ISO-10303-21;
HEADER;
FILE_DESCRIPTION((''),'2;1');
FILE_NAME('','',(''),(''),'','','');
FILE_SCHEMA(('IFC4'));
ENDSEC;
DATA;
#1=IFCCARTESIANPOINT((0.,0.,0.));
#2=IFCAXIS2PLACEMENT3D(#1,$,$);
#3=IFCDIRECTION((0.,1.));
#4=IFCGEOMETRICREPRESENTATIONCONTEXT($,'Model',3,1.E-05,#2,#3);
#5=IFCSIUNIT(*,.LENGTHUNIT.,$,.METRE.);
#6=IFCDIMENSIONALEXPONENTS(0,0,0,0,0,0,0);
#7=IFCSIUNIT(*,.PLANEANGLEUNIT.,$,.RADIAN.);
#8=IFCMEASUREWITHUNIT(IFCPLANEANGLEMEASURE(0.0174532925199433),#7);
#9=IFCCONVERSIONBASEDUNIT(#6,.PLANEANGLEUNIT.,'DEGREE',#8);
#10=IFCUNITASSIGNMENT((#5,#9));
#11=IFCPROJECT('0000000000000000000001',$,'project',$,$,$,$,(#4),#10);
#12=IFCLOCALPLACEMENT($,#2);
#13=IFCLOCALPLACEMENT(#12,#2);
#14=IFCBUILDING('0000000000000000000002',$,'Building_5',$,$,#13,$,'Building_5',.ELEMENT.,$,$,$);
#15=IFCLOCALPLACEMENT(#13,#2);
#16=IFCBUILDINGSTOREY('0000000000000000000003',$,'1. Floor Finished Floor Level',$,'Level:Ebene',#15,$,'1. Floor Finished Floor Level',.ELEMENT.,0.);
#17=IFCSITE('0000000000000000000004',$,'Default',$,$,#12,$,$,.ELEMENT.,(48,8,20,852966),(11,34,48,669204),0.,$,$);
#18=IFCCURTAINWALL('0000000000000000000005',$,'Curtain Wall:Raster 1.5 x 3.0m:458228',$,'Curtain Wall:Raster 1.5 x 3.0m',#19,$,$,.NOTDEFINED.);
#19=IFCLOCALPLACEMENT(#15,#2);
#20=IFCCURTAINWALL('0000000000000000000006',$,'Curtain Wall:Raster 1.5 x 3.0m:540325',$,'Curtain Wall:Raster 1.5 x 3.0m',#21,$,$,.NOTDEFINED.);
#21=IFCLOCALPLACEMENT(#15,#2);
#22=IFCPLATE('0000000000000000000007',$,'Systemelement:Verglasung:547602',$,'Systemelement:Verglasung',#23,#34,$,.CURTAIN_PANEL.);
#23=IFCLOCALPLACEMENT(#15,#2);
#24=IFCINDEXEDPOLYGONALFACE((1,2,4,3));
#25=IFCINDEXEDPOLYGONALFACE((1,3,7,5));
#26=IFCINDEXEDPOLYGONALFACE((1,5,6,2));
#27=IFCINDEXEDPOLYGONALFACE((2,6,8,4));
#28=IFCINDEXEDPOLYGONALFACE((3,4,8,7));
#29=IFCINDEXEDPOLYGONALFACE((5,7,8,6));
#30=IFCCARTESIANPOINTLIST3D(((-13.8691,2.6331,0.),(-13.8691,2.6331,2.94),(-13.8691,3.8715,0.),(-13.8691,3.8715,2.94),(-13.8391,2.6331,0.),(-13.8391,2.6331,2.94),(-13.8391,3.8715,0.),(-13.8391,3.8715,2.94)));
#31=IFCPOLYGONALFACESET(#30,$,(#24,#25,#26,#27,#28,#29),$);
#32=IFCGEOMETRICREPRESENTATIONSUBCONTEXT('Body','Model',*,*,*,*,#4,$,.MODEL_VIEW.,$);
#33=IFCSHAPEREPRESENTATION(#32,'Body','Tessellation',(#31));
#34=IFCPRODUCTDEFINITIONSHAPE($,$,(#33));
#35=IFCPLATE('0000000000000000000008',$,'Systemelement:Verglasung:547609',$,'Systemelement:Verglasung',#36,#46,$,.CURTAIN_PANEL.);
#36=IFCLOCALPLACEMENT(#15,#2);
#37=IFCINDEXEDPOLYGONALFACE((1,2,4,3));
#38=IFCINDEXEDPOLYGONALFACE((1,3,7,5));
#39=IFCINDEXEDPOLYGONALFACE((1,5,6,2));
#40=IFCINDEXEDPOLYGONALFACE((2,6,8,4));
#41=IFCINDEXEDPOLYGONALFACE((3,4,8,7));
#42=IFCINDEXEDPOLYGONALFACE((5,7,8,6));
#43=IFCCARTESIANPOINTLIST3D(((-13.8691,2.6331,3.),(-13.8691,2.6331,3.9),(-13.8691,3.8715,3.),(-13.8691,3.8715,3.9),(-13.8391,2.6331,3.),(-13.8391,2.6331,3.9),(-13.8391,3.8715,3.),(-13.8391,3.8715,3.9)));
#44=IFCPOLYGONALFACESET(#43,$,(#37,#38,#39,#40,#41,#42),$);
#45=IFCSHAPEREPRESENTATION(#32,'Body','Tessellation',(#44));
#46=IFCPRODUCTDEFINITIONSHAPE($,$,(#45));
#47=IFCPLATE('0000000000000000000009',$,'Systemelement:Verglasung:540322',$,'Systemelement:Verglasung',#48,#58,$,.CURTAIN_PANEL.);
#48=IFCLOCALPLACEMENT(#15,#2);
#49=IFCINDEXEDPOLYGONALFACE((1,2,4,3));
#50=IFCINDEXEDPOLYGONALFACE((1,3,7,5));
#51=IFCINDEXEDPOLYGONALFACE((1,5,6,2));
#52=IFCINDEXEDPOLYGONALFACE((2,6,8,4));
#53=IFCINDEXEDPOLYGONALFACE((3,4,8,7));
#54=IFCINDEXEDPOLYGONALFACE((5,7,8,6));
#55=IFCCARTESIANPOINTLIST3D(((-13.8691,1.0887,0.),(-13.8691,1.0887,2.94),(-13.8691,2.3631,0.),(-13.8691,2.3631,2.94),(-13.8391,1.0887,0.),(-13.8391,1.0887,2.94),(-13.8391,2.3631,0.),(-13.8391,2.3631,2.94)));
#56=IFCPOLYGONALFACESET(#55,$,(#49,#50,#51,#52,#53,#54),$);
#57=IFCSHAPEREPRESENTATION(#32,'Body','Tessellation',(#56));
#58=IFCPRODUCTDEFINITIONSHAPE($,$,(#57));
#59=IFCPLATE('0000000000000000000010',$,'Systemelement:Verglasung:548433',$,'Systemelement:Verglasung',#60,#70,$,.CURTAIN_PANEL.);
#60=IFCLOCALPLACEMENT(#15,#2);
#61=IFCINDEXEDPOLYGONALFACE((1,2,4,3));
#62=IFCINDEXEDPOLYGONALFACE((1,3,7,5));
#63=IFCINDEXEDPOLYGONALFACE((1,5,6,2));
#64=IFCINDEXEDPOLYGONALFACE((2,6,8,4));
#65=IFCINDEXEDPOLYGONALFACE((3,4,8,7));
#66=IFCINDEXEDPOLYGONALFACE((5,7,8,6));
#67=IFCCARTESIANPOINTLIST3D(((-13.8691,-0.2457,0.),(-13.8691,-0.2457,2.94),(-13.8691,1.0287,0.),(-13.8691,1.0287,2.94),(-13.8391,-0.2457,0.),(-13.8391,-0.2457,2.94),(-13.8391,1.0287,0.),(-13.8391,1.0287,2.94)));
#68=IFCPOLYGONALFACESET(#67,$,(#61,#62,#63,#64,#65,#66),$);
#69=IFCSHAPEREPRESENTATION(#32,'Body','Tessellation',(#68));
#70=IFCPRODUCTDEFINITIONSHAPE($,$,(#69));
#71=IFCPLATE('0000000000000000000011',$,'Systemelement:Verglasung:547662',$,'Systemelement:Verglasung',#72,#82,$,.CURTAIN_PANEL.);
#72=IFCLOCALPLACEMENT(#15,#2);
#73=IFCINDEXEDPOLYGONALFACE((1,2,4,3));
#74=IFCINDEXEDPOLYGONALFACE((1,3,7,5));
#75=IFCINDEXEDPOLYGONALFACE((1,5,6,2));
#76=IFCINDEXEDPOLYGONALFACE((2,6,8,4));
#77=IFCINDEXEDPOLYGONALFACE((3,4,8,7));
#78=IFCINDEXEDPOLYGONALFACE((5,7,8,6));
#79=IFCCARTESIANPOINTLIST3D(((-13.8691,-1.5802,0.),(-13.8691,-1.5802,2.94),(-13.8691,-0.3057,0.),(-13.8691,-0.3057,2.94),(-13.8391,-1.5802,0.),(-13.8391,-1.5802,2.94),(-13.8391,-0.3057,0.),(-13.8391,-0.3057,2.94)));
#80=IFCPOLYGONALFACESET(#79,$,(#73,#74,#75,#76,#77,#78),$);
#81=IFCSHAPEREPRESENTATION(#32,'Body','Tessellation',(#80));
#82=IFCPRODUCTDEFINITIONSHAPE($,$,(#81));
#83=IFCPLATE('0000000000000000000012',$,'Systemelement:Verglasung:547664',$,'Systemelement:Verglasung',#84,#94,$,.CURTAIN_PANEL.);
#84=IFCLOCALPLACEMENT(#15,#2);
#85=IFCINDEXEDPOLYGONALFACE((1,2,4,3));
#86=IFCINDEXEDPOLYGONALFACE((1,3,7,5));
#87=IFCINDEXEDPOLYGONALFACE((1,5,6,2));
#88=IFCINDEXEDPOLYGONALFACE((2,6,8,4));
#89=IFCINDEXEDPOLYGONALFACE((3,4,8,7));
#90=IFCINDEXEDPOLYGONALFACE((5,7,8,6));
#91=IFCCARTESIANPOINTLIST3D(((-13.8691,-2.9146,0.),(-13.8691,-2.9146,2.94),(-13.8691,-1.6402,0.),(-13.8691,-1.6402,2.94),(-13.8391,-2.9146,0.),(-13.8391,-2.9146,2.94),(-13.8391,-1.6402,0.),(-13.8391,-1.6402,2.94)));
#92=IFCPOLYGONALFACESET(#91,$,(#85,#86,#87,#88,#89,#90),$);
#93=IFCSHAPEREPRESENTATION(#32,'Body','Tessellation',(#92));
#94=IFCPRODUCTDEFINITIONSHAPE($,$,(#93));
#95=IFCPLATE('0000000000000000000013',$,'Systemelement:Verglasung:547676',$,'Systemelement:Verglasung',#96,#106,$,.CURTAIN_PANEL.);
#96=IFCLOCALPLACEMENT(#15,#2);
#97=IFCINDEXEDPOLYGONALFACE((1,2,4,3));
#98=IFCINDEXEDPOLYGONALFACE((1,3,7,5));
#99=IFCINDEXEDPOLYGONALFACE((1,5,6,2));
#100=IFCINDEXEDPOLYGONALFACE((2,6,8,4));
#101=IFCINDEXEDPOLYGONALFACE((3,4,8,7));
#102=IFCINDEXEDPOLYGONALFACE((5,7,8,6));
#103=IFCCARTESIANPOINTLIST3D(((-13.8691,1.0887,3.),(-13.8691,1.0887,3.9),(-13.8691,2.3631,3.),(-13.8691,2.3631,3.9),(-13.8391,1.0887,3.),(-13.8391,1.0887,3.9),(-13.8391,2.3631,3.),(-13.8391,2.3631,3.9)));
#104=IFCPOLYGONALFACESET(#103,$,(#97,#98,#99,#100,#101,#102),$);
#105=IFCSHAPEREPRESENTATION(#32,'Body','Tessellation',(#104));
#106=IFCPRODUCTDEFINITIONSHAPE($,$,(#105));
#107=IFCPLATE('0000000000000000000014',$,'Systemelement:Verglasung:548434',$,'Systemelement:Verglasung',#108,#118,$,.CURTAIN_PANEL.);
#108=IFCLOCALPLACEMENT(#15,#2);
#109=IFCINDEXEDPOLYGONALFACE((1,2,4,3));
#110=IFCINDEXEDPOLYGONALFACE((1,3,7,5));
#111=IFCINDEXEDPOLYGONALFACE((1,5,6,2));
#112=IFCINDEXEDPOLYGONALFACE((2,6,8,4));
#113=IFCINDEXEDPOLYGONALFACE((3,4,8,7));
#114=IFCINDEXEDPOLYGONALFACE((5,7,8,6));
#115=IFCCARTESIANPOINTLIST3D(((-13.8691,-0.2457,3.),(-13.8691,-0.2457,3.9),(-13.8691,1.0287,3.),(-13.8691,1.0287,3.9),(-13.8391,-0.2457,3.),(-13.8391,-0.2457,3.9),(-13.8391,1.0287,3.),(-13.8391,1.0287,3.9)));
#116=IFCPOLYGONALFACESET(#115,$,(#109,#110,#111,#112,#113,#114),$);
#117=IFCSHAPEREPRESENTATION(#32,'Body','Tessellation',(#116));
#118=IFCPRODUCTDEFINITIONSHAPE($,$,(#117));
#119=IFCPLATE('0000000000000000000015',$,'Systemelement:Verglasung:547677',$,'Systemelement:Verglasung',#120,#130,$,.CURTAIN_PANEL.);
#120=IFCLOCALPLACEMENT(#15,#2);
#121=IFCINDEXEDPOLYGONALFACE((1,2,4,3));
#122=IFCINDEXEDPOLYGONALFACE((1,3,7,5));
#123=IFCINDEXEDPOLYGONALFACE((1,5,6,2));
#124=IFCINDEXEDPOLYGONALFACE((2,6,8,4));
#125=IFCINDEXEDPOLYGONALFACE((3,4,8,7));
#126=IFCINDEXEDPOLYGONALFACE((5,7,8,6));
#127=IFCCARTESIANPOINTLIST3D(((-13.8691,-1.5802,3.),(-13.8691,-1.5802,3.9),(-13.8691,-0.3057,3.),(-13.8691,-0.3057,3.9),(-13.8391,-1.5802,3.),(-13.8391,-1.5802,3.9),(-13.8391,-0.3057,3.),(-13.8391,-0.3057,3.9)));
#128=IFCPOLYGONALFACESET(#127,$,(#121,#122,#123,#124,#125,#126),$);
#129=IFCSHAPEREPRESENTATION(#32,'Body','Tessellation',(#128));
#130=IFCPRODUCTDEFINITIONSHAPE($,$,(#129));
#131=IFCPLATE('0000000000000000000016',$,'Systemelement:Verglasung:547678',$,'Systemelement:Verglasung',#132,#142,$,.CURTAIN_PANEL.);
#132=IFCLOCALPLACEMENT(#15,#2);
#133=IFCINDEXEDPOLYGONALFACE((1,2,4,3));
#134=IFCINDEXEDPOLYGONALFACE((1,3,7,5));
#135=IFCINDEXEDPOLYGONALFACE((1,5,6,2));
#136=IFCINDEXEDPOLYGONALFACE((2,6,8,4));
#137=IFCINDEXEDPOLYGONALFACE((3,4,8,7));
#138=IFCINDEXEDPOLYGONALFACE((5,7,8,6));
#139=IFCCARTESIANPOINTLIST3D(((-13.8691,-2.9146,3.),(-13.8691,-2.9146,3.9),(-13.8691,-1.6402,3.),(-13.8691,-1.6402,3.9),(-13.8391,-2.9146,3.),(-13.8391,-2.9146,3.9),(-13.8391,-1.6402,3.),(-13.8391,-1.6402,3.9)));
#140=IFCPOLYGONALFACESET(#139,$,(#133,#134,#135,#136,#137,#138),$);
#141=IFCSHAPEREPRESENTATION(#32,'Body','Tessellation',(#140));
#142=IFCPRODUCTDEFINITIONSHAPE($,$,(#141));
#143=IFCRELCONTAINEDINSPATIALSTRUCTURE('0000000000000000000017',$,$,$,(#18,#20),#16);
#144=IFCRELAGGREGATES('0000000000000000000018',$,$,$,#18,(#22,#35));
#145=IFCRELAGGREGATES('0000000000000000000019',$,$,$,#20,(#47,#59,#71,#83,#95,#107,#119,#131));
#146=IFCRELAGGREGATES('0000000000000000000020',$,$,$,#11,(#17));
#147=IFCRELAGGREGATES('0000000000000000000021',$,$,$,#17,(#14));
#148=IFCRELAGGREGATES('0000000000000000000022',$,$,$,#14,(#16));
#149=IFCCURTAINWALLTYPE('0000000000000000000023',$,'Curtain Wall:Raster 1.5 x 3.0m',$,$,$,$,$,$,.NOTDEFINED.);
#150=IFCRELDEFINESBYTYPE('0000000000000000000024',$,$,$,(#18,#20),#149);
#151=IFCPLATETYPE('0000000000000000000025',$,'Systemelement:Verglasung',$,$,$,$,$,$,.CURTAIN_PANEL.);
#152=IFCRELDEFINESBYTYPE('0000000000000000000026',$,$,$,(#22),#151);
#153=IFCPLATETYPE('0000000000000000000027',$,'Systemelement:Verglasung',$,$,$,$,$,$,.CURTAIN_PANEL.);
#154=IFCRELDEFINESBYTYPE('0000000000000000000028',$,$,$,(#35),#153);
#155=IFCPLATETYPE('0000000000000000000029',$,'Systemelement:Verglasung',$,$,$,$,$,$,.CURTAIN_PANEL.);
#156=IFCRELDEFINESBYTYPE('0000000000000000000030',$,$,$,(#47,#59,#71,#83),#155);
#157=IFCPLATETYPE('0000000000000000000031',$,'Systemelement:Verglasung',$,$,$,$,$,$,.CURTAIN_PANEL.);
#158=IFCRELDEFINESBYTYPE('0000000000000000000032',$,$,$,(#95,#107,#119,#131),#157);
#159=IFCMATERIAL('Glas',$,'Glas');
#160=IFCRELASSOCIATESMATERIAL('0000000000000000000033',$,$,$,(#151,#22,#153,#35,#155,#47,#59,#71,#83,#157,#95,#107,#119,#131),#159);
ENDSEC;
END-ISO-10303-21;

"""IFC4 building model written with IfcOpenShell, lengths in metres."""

from ifc_helpers import new_model, entity, si_unit, converted_unit, direction, frame, origin, place, context, subcontext, project, spatial, indexed_curve, outline, extrude, source, transform, mapped, material, type_object, type_shapes, element, aggregate, save


model = new_model("IFC4")

# Units and contexts
model_context = context("Model", 3, precision=1e-05, world=origin(), true_north=direction((0.0, 1.0)))
body_context = subcontext(model_context, "Body", "Model", "MODEL_VIEW")
ifc_project = project(units=[si_unit("LENGTHUNIT", "METRE"), converted_unit("PLANEANGLEUNIT", "DEGREE", entity("IfcPlaneAngleMeasure", 0.0174532925199433), si_unit("PLANEANGLEUNIT", "RADIAN"), dimensions=[0, 0, 0, 0, 0, 0, 0])], contexts=[model_context])

# Site, building, storey
site_placement = place(None, origin())
site = spatial("IfcSite", under=ifc_project, at=site_placement, Name="Default", CompositionType="ELEMENT", RefLatitude=(48, 8, 20, 852966), RefLongitude=(11, 34, 48, 669204), RefElevation=0.0)
building_placement = place(site_placement, origin())
building = spatial("IfcBuilding", under=site, at=building_placement, Name="Building_5", LongName="Building_5", CompositionType="ELEMENT")
storey_placement = place(building_placement, origin())
storey = spatial("IfcBuildingStorey", under=building, at=storey_placement, Name="1. Floor Finished Floor Level", ObjectType="Level:Ebene", LongName="1. Floor Finished Floor Level", CompositionType="ELEMENT", Elevation=0.0)

# Curtain wall
curtain_wall_type = type_object("IfcCurtainWallType", Name="Curtain Wall:Raster 1.5 x 3.0m", PredefinedType="NOTDEFINED")
curtain_wall_1_placement = place(storey_placement, origin())
curtain_wall_1 = element("IfcCurtainWall", 1, at=curtain_wall_1_placement, inside=storey, type_object=curtain_wall_type, Name="Curtain Wall:Raster 1.5 x 3.0m:458228", ObjectType="Curtain Wall:Raster 1.5 x 3.0m", PredefinedType="NOTDEFINED")

# Curtain wall
curtain_wall_2_placement = place(storey_placement, origin())
curtain_wall_2 = element("IfcCurtainWall", 2, at=curtain_wall_2_placement, inside=storey, type_object=curtain_wall_type, Name="Curtain Wall:Raster 1.5 x 3.0m:540325", ObjectType="Curtain Wall:Raster 1.5 x 3.0m", PredefinedType="NOTDEFINED")

# Plates
ifc_material_1 = material(Name="Glas", Category="Glas")
plate_type_1 = type_object("IfcPlateType", Name="Systemelement:Verglasung", PredefinedType="CURTAIN_PANEL", material=ifc_material_1)
shared_shape_1 = source(origin(), body_context, "Body", "SweptSolid", [
    extrude(outline(indexed_curve([(-0.015, -0.6192), (0.015, -0.6192), (0.015, 0.6192), (-0.015, 0.6192), (-0.015, -0.6192)], self_intersect=False)), frame((0.0, 0.0, 0.0), z_axis=(0.0, 0.0, 1.0), x_axis=(0.0, 1.0, 0.0)), (0.0, 0.0, 1.0), 2.94),
])
type_shapes(plate_type_1, [shared_shape_1])
plate_1_placement = place(curtain_wall_1_placement, frame((-13.8541, 3.2523, 0.0), z_axis=(0.0, 0.0, 1.0), x_axis=(0.0, -1.0, 0.0)))
plate_1 = element("IfcPlate", 3, at=plate_1_placement, type_object=plate_type_1, material=ifc_material_1, Name="Systemelement:Verglasung:547602", ObjectType="Systemelement:Verglasung", PredefinedType="CURTAIN_PANEL", context=body_context, shape_type="MappedRepresentation", body=[
    mapped(shared_shape_1, transform((0.0, 0.0, 0.0), scale=1.0)),
])
plate_type_2 = type_object("IfcPlateType", Name="Systemelement:Verglasung", PredefinedType="CURTAIN_PANEL", material=ifc_material_1)
shared_shape_2 = source(origin(), body_context, "Body", "SweptSolid", [
    extrude(outline(indexed_curve([(-0.015, -0.6192), (0.015, -0.6192), (0.015, 0.6192), (-0.015, 0.6192), (-0.015, -0.6192)], self_intersect=False)), frame((0.0, 0.0, 0.0), z_axis=(0.0, 0.0, 1.0), x_axis=(0.0, 1.0, 0.0)), (0.0, 0.0, 1.0), 0.9),
])
type_shapes(plate_type_2, [shared_shape_2])
plate_2_placement = place(curtain_wall_1_placement, frame((-13.8541, 3.2523, 3.0), z_axis=(0.0, 0.0, 1.0), x_axis=(0.0, -1.0, 0.0)))
plate_2 = element("IfcPlate", 4, at=plate_2_placement, type_object=plate_type_2, material=ifc_material_1, Name="Systemelement:Verglasung:547609", ObjectType="Systemelement:Verglasung", PredefinedType="CURTAIN_PANEL", context=body_context, shape_type="MappedRepresentation", body=[
    mapped(shared_shape_2, transform((0.0, 0.0, 0.0), scale=1.0)),
])
aggregate(curtain_wall_1, [plate_1, plate_2])
plate_type_3 = type_object("IfcPlateType", Name="Systemelement:Verglasung", PredefinedType="CURTAIN_PANEL", material=ifc_material_1)
shared_shape_3 = source(origin(), body_context, "Body", "SweptSolid", [
    extrude(outline(indexed_curve([(-0.015, -0.6372), (0.015, -0.6372), (0.015, 0.6372), (-0.015, 0.6372), (-0.015, -0.6372)], self_intersect=False)), frame((0.0, 0.0, 0.0), z_axis=(0.0, 0.0, 1.0), x_axis=(0.0, 1.0, 0.0)), (0.0, 0.0, 1.0), 2.94),
])
type_shapes(plate_type_3, [shared_shape_3])
plate_3_placement = place(curtain_wall_2_placement, frame((-13.8541, 1.7259, 0.0), z_axis=(0.0, 0.0, 1.0), x_axis=(0.0, -1.0, 0.0)))
plate_3 = element("IfcPlate", 5, at=plate_3_placement, type_object=plate_type_3, material=ifc_material_1, Name="Systemelement:Verglasung:540322", ObjectType="Systemelement:Verglasung", PredefinedType="CURTAIN_PANEL", context=body_context, shape_type="MappedRepresentation", body=[
    mapped(shared_shape_3, transform((0.0, 0.0, 0.0), scale=1.0)),
])
plate_4_placement = place(curtain_wall_2_placement, frame((-13.8541, 0.3915, 0.0), z_axis=(0.0, 0.0, 1.0), x_axis=(0.0, -1.0, 0.0)))
plate_4 = element("IfcPlate", 6, at=plate_4_placement, type_object=plate_type_3, material=ifc_material_1, Name="Systemelement:Verglasung:548433", ObjectType="Systemelement:Verglasung", PredefinedType="CURTAIN_PANEL", context=body_context, shape_type="MappedRepresentation", body=[
    mapped(shared_shape_3, transform((0.0, 0.0, 0.0), scale=1.0)),
])
plate_5_placement = place(curtain_wall_2_placement, frame((-13.8541, -0.943, 0.0), z_axis=(0.0, 0.0, 1.0), x_axis=(0.0, -1.0, 0.0)))
plate_5 = element("IfcPlate", 7, at=plate_5_placement, type_object=plate_type_3, material=ifc_material_1, Name="Systemelement:Verglasung:547662", ObjectType="Systemelement:Verglasung", PredefinedType="CURTAIN_PANEL", context=body_context, shape_type="MappedRepresentation", body=[
    mapped(shared_shape_3, transform((0.0, 0.0, 0.0), scale=1.0)),
])
plate_6_placement = place(curtain_wall_2_placement, frame((-13.8541, -2.2774, 0.0), z_axis=(0.0, 0.0, 1.0), x_axis=(0.0, -1.0, 0.0)))
plate_6 = element("IfcPlate", 8, at=plate_6_placement, type_object=plate_type_3, material=ifc_material_1, Name="Systemelement:Verglasung:547664", ObjectType="Systemelement:Verglasung", PredefinedType="CURTAIN_PANEL", context=body_context, shape_type="MappedRepresentation", body=[
    mapped(shared_shape_3, transform((0.0, 0.0, 0.0), scale=1.0)),
])
plate_type_4 = type_object("IfcPlateType", Name="Systemelement:Verglasung", PredefinedType="CURTAIN_PANEL", material=ifc_material_1)
shared_shape_4 = source(origin(), body_context, "Body", "SweptSolid", [
    extrude(outline(indexed_curve([(-0.015, -0.6372), (0.015, -0.6372), (0.015, 0.6372), (-0.015, 0.6372), (-0.015, -0.6372)], self_intersect=False)), frame((0.0, 0.0, 0.0), z_axis=(0.0, 0.0, 1.0), x_axis=(0.0, 1.0, 0.0)), (0.0, 0.0, 1.0), 0.9),
])
type_shapes(plate_type_4, [shared_shape_4])
plate_7_placement = place(curtain_wall_2_placement, frame((-13.8541, 1.7259, 3.0), z_axis=(0.0, 0.0, 1.0), x_axis=(0.0, -1.0, 0.0)))
plate_7 = element("IfcPlate", 9, at=plate_7_placement, type_object=plate_type_4, material=ifc_material_1, Name="Systemelement:Verglasung:547676", ObjectType="Systemelement:Verglasung", PredefinedType="CURTAIN_PANEL", context=body_context, shape_type="MappedRepresentation", body=[
    mapped(shared_shape_4, transform((0.0, 0.0, 0.0), scale=1.0)),
])
plate_8_placement = place(curtain_wall_2_placement, frame((-13.8541, 0.3915, 3.0), z_axis=(0.0, 0.0, 1.0), x_axis=(0.0, -1.0, 0.0)))
plate_8 = element("IfcPlate", 10, at=plate_8_placement, type_object=plate_type_4, material=ifc_material_1, Name="Systemelement:Verglasung:548434", ObjectType="Systemelement:Verglasung", PredefinedType="CURTAIN_PANEL", context=body_context, shape_type="MappedRepresentation", body=[
    mapped(shared_shape_4, transform((0.0, 0.0, 0.0), scale=1.0)),
])
plate_9_placement = place(curtain_wall_2_placement, frame((-13.8541, -0.943, 3.0), z_axis=(0.0, 0.0, 1.0), x_axis=(0.0, -1.0, 0.0)))
plate_9 = element("IfcPlate", 11, at=plate_9_placement, type_object=plate_type_4, material=ifc_material_1, Name="Systemelement:Verglasung:547677", ObjectType="Systemelement:Verglasung", PredefinedType="CURTAIN_PANEL", context=body_context, shape_type="MappedRepresentation", body=[
    mapped(shared_shape_4, transform((0.0, 0.0, 0.0), scale=1.0)),
])
plate_10_placement = place(curtain_wall_2_placement, frame((-13.8541, -2.2774, 3.0), z_axis=(0.0, 0.0, 1.0), x_axis=(0.0, -1.0, 0.0)))
plate_10 = element("IfcPlate", 12, at=plate_10_placement, type_object=plate_type_4, material=ifc_material_1, Name="Systemelement:Verglasung:547678", ObjectType="Systemelement:Verglasung", PredefinedType="CURTAIN_PANEL", context=body_context, shape_type="MappedRepresentation", body=[
    mapped(shared_shape_4, transform((0.0, 0.0, 0.0), scale=1.0)),
])
aggregate(curtain_wall_2, [plate_3, plate_4, plate_5, plate_6, plate_7, plate_8, plate_9, plate_10])

save(model, "model.ifc")
